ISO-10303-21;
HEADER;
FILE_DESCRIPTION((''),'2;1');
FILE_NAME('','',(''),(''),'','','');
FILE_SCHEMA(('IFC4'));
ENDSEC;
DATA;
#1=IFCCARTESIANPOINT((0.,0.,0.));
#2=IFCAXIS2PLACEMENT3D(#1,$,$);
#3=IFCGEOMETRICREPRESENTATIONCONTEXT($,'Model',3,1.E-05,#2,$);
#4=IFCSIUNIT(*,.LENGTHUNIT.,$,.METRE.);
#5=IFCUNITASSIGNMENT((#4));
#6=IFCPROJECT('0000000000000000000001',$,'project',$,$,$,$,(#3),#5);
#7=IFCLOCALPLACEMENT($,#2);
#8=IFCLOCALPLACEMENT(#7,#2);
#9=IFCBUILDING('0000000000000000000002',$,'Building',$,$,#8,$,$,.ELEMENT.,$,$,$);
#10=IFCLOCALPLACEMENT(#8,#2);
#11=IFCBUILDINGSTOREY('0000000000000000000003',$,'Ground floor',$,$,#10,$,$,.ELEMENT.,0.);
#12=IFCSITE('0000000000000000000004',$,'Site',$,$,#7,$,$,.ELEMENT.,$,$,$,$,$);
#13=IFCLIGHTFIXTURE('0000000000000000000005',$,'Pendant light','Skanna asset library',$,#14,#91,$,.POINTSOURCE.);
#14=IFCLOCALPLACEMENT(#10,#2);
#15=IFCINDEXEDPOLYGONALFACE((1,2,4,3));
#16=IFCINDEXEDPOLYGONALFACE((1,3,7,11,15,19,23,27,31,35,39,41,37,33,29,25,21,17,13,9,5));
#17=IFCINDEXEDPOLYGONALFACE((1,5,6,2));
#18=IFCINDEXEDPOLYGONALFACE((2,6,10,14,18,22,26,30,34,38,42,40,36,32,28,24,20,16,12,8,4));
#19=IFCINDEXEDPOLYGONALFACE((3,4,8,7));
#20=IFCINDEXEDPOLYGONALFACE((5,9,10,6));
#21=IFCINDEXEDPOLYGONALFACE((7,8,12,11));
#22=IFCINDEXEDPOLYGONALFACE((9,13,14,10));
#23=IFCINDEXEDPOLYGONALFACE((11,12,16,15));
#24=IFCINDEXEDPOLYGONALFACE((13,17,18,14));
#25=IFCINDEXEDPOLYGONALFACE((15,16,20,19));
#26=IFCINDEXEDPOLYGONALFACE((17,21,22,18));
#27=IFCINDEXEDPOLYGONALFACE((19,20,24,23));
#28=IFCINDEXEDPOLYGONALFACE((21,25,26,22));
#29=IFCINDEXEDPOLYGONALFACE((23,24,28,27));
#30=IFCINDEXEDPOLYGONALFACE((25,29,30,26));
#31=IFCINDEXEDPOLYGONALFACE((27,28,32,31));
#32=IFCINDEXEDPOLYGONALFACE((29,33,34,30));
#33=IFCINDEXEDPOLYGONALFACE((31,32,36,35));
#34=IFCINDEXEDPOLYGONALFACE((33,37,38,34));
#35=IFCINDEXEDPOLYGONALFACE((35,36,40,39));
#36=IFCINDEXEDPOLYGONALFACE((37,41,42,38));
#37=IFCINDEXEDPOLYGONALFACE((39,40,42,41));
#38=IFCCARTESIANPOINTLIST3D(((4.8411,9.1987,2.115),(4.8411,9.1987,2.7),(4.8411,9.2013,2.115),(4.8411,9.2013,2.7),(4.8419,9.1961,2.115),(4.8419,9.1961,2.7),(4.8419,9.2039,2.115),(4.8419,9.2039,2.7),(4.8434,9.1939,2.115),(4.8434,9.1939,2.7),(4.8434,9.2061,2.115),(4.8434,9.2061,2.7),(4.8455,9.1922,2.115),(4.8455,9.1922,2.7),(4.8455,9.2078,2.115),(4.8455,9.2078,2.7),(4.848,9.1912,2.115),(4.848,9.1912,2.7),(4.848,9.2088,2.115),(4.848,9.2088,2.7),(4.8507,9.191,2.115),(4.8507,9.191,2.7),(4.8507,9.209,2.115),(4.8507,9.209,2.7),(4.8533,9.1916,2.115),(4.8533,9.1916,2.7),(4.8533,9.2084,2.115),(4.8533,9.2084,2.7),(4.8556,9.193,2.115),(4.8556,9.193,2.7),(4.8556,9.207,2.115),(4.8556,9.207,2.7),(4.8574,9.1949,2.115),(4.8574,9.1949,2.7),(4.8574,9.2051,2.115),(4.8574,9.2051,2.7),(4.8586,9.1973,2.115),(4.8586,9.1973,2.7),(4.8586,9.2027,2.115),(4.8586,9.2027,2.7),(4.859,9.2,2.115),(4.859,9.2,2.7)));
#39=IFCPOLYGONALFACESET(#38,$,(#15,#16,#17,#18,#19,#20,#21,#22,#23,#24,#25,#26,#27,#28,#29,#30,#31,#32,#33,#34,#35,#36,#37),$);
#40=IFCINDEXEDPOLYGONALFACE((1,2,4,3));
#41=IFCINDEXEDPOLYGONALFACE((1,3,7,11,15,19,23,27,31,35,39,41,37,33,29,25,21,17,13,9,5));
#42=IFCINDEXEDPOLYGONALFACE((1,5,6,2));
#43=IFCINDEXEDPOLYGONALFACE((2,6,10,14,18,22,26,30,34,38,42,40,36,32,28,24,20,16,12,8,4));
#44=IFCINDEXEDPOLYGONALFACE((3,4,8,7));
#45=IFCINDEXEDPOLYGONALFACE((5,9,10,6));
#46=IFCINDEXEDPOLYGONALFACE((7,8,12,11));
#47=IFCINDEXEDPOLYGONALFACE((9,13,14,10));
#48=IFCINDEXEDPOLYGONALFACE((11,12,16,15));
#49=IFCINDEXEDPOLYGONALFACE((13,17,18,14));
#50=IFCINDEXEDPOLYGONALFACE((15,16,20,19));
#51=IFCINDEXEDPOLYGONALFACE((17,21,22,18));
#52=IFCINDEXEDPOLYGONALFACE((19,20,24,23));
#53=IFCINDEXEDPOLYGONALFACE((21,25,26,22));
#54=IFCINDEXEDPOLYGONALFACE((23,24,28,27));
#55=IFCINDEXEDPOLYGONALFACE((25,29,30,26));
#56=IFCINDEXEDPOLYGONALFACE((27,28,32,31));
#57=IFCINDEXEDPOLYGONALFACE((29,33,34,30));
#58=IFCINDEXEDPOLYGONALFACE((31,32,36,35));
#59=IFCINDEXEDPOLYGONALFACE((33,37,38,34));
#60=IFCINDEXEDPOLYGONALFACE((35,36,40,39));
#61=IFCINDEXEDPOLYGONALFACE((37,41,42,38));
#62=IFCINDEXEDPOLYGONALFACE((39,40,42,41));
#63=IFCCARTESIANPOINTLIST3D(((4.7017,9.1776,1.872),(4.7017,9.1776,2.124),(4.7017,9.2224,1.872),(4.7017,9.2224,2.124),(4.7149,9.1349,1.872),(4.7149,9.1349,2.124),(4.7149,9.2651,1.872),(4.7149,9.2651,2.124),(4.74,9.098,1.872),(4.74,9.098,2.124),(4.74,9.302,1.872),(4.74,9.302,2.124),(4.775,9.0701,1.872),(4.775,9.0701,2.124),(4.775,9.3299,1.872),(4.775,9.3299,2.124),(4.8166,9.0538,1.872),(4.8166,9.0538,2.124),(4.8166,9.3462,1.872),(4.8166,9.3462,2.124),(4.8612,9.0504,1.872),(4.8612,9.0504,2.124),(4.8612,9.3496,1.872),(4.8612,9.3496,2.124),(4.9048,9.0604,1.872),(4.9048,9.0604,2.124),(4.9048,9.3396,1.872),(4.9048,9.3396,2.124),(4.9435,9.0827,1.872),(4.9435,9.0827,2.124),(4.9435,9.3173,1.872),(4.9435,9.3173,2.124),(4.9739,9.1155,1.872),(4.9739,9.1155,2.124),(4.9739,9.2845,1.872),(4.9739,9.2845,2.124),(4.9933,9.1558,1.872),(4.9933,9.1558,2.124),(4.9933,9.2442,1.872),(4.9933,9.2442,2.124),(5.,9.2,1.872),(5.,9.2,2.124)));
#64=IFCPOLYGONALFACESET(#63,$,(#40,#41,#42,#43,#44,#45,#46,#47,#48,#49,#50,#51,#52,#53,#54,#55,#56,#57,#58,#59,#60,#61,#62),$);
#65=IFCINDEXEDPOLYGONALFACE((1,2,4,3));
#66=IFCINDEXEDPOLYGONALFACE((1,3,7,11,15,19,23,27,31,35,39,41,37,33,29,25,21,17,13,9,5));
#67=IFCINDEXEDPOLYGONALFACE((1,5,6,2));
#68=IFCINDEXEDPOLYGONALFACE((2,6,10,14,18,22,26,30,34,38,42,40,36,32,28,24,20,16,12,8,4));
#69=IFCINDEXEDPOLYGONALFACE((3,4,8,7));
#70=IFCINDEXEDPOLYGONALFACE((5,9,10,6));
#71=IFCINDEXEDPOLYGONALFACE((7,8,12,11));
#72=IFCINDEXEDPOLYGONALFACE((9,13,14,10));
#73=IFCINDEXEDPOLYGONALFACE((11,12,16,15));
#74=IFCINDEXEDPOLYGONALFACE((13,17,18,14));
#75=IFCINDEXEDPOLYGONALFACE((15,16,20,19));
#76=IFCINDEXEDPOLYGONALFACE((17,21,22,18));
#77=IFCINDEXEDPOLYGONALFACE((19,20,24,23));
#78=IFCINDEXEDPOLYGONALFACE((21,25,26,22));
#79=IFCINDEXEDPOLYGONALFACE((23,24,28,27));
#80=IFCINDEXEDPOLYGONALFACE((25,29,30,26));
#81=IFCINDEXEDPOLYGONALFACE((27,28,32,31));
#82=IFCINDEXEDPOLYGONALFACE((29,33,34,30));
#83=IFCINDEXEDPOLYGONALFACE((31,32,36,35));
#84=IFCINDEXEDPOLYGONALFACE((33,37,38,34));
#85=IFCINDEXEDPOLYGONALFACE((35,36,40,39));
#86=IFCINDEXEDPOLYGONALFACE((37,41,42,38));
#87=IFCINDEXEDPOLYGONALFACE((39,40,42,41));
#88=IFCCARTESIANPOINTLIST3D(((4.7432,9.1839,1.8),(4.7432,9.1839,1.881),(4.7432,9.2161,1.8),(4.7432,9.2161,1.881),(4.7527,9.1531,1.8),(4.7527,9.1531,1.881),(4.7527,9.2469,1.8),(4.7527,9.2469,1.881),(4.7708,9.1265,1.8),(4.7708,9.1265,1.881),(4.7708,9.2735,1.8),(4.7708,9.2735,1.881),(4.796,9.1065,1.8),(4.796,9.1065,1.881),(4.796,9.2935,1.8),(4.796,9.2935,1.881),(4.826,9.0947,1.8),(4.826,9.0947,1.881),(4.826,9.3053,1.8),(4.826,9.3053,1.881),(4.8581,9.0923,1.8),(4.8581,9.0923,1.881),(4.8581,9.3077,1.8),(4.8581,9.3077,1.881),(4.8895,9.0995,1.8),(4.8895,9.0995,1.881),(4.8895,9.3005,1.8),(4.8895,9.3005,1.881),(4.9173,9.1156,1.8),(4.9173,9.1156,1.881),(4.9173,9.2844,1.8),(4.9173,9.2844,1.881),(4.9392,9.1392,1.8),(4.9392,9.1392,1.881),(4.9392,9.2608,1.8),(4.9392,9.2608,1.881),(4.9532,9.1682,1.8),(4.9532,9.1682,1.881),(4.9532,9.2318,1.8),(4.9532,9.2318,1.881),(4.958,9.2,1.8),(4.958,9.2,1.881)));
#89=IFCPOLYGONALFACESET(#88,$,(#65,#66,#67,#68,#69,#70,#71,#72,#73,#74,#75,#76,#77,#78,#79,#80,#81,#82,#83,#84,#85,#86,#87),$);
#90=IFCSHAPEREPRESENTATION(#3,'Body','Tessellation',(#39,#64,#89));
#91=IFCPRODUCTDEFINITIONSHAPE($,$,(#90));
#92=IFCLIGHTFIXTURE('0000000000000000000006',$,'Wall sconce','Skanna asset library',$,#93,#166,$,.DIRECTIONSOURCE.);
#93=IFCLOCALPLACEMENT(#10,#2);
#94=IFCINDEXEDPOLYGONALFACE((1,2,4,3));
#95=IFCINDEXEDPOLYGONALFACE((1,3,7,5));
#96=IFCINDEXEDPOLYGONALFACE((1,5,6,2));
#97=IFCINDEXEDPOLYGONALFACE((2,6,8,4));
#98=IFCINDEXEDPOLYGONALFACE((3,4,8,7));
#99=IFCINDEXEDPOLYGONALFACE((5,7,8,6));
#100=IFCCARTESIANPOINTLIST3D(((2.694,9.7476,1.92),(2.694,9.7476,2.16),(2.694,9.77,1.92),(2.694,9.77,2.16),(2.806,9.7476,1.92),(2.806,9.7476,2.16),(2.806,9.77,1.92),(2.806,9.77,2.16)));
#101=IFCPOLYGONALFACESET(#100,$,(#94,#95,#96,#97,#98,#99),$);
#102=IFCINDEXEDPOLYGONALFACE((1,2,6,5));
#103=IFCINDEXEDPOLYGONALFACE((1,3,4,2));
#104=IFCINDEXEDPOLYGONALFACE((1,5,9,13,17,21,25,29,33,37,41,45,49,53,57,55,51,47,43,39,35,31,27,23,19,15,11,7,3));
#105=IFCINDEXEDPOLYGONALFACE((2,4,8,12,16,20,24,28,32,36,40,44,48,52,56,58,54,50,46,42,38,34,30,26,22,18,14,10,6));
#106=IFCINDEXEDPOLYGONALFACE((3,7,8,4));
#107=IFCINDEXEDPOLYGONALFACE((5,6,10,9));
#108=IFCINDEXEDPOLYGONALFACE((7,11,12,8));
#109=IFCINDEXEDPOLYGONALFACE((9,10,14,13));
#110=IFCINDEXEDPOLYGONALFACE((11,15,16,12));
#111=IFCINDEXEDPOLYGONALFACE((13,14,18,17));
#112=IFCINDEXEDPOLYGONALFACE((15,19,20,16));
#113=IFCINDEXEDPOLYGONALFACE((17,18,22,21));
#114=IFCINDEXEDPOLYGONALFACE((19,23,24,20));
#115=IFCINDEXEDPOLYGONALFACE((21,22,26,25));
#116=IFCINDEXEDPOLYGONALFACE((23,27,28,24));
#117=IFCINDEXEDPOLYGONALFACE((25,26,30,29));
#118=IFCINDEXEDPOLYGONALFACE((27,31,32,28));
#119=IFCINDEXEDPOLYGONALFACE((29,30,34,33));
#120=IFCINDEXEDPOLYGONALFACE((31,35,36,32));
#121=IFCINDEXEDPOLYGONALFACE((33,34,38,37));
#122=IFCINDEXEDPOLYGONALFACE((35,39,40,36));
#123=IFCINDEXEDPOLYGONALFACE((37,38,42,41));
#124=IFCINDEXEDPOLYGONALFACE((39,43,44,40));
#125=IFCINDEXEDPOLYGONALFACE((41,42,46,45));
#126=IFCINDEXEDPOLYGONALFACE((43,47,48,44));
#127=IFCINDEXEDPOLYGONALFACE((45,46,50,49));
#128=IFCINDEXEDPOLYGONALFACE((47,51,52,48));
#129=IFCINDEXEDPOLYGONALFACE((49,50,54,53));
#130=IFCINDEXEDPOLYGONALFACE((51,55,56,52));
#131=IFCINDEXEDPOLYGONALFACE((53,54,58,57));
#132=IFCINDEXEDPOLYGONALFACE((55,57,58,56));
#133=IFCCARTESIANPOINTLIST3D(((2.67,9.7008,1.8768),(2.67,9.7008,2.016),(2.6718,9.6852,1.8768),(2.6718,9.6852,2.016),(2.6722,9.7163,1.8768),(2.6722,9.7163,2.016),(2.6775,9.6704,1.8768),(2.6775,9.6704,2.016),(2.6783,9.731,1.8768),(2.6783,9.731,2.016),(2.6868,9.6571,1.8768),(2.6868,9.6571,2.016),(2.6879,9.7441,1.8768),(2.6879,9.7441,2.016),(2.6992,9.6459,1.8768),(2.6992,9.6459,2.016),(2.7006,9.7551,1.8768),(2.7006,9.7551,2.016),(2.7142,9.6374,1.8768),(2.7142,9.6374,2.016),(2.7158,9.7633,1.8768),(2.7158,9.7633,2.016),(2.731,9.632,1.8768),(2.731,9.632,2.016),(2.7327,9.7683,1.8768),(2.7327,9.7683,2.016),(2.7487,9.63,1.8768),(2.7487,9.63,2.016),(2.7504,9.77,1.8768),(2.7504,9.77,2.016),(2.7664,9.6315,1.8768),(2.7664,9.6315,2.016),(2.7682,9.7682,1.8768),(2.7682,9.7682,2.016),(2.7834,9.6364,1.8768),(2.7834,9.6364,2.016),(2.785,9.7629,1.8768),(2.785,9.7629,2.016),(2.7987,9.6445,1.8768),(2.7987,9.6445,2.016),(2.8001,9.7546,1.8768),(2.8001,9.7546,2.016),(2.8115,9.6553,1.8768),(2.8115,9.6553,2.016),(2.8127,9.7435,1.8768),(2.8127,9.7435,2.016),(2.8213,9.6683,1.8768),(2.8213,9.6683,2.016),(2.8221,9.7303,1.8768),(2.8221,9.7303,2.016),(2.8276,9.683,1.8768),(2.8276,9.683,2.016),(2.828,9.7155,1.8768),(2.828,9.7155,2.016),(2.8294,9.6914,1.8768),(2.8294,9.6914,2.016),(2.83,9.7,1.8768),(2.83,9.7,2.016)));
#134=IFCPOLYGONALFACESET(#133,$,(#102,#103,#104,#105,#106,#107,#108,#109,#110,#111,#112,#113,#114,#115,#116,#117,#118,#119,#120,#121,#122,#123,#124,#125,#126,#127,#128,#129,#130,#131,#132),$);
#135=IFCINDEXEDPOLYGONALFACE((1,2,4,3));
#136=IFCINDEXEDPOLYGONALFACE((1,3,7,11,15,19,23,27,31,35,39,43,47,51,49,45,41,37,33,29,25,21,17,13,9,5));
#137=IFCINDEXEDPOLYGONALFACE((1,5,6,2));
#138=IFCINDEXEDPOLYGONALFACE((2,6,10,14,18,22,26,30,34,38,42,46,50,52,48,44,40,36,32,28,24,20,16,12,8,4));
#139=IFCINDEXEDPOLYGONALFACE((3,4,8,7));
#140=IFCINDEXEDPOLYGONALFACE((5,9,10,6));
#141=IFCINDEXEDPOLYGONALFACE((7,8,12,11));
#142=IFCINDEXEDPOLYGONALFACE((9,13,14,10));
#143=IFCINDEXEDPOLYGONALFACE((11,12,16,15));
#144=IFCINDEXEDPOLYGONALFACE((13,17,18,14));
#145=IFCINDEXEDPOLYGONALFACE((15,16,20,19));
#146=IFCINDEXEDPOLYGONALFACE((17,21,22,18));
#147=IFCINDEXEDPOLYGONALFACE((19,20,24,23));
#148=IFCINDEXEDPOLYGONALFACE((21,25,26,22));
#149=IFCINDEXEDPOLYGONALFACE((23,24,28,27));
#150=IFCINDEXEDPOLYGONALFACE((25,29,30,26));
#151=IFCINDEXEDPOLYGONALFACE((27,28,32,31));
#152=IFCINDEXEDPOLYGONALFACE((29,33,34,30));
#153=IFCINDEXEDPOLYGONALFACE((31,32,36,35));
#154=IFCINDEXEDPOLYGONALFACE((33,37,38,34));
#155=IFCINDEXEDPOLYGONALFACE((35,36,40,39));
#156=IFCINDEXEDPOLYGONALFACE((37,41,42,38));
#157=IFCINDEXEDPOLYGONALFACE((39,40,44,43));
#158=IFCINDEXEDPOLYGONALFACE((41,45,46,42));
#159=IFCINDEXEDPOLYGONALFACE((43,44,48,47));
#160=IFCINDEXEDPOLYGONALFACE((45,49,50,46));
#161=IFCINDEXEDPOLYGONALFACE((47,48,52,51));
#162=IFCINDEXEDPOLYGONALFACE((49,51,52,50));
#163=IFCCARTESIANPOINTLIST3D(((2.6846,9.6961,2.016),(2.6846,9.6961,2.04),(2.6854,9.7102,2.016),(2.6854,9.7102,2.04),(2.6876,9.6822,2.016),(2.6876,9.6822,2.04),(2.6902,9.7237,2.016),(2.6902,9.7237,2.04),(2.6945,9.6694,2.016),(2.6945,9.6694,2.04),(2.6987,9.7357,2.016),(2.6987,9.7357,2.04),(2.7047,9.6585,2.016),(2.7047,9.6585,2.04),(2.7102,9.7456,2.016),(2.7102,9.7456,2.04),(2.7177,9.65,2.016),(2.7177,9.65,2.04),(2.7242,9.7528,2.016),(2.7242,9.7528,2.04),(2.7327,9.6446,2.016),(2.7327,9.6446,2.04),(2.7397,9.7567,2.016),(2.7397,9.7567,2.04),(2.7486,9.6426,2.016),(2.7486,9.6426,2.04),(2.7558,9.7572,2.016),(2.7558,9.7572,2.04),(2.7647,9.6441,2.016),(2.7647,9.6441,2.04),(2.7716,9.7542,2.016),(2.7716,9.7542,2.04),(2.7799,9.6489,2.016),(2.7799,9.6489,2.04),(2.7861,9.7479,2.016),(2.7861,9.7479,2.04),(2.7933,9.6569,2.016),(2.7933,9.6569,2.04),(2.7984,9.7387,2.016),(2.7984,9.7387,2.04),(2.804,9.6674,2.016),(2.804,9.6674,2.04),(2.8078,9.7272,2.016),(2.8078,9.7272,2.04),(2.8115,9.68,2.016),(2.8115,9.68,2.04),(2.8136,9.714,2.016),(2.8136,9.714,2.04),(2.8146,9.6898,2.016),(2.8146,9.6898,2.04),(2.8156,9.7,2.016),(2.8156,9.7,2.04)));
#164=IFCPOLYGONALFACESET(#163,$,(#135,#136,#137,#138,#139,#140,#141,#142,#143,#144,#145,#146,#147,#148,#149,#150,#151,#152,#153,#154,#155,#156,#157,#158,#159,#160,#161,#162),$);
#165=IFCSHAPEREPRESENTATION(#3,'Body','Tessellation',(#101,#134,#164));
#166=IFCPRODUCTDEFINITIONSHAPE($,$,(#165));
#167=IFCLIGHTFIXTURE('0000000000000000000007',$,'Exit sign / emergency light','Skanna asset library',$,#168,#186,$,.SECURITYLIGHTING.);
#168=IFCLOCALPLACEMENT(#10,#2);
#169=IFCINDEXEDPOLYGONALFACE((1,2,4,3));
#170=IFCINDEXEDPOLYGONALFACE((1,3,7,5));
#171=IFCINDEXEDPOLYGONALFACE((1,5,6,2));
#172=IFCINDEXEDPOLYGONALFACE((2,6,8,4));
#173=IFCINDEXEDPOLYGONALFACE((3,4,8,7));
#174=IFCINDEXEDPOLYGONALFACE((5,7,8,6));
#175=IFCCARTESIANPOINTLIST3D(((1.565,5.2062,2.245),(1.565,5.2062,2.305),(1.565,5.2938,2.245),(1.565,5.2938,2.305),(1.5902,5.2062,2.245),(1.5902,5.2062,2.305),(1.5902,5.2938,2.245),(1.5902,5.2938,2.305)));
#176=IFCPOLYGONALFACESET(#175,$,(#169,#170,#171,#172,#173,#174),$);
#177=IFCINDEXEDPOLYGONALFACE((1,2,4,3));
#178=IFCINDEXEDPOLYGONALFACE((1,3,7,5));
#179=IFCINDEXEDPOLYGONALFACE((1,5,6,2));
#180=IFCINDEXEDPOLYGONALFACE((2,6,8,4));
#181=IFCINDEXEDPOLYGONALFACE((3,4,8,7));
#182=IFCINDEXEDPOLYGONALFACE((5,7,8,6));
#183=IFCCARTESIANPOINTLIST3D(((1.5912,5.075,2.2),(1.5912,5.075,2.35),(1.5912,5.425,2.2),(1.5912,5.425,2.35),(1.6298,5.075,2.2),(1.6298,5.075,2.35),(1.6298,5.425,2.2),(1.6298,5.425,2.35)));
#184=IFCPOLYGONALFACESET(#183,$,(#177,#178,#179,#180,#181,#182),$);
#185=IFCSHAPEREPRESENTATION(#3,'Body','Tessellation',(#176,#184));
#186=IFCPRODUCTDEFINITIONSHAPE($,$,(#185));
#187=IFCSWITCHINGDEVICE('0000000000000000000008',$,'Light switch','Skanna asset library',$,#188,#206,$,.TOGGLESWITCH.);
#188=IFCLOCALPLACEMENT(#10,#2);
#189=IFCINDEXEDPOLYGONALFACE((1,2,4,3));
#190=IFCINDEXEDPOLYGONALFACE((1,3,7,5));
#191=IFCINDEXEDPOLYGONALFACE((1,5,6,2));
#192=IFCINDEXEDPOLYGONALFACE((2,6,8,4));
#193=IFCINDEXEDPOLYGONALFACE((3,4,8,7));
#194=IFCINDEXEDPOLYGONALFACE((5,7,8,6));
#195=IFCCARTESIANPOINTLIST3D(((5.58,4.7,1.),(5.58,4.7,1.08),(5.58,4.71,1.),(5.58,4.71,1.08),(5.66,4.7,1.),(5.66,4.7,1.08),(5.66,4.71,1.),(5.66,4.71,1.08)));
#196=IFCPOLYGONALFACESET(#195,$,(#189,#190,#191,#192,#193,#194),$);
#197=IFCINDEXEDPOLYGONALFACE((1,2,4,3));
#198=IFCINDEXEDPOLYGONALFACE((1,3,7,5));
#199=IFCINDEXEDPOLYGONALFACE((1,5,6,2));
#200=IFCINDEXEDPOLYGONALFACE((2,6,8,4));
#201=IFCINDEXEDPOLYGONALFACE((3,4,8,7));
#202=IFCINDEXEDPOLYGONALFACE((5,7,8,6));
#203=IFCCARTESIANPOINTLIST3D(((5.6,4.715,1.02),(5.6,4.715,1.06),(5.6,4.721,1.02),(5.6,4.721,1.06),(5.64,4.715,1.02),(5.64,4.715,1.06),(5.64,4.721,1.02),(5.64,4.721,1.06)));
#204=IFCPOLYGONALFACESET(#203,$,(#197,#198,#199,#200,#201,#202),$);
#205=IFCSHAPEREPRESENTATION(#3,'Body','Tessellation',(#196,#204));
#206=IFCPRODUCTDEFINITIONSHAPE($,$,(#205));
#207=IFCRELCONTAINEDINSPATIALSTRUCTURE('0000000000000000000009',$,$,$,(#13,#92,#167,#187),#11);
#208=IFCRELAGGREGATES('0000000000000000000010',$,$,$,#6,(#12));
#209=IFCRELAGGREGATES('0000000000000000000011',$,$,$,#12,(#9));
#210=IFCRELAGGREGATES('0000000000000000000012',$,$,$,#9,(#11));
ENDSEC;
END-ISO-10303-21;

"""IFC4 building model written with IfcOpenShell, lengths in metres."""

from ifc_helpers import new_model, si_unit, frame, frame_2d, origin, origin_2d, place, context, project, spatial, rectangle, circle, ellipse, extrude, element, save


model = new_model("IFC4")

# Units and contexts
model_context = context("Model", 3, precision=1e-05, world=origin())
ifc_project = project(units=[si_unit("LENGTHUNIT", "METRE")], contexts=[model_context])

# Site, building, storey
site_placement = place(None, origin())
site = spatial("IfcSite", under=ifc_project, at=site_placement, Name="Site", CompositionType="ELEMENT")
building_placement = place(site_placement, origin())
building = spatial("IfcBuilding", under=site, at=building_placement, Name="Building", CompositionType="ELEMENT")
storey_placement = place(building_placement, origin())
storey = spatial("IfcBuildingStorey", under=building, at=storey_placement, Name="Ground floor", CompositionType="ELEMENT", Elevation=0.0)

# Light fixtures
light_fixture_1_placement = place(storey_placement, frame((4.85, 9.2, 1.8), z_axis=(0.0, 0.0, 1.0), x_axis=(1.0, 0.0, 0.0)))
element("IfcLightFixture", 1, at=light_fixture_1_placement, inside=storey, Name="Pendant light", Description="Skanna asset library", PredefinedType="POINTSOURCE", context=model_context, shape_type="SweptSolid", body=[
    extrude(circle(Radius=0.009, at=origin_2d()), frame((0.0, 0.0, 0.315)), (0.0, 0.0, 1.0), 0.585),
    extrude(circle(Radius=0.15, at=origin_2d()), frame((0.0, 0.0, 0.072)), (0.0, 0.0, 1.0), 0.252),
    extrude(circle(Radius=0.108, at=origin_2d()), origin(), (0.0, 0.0, 1.0), 0.081),
])
light_fixture_2_placement = place(storey_placement, frame((2.75, 9.7, 1.8), z_axis=(0.0, 0.0, 1.0), x_axis=(1.0, 0.0, 0.0)))
element("IfcLightFixture", 2, at=light_fixture_2_placement, inside=storey, Name="Wall sconce", Description="Skanna asset library", PredefinedType="DIRECTIONSOURCE", context=model_context, shape_type="SweptSolid", body=[
    extrude(rectangle(XDim=0.112, YDim=0.0224, at=frame_2d((0.0, 0.0588))), frame((0.0, 0.0, 0.12)), (0.0, 0.0, 1.0), 0.24),
    extrude(ellipse(SemiAxis1=0.08, SemiAxis2=0.07, at=origin_2d()), frame((0.0, 0.0, 0.0768)), (0.0, 0.0, 1.0), 0.1392),
    extrude(ellipse(SemiAxis1=0.0656, SemiAxis2=0.0574, at=origin_2d()), frame((0.0, 0.0, 0.216)), (0.0, 0.0, 1.0), 0.024),
])
light_fixture_3_placement = place(storey_placement, frame((1.6, 5.25, 2.2), z_axis=(0.0, 0.0, 1.0), x_axis=(0.0, 1.0, 0.0)))
element("IfcLightFixture", 3, at=light_fixture_3_placement, inside=storey, Name="Exit sign / emergency light", Description="Skanna asset library", PredefinedType="SECURITYLIGHTING", context=model_context, shape_type="SweptSolid", body=[
    extrude(rectangle(XDim=0.0875, YDim=0.0252, at=frame_2d((0.0, 0.0224))), frame((0.0, 0.0, 0.045)), (0.0, 0.0, 1.0), 0.06),
    extrude(rectangle(XDim=0.35, YDim=0.0385, at=frame_2d((0.0, -0.0105))), origin(), (0.0, 0.0, 1.0), 0.15),
])

# Switching device
switching_device_placement = place(storey_placement, frame((5.62, 4.71, 1.0), z_axis=(0.0, 0.0, 1.0), x_axis=(-1.0, 0.0, 0.0)))
element("IfcSwitchingDevice", 4, at=switching_device_placement, inside=storey, Name="Light switch", Description="Skanna asset library", PredefinedType="TOGGLESWITCH", context=model_context, shape_type="SweptSolid", body=[
    extrude(rectangle(XDim=0.08, YDim=0.01, at=frame_2d((0.0, 0.005))), origin(), (0.0, 0.0, 1.0), 0.08),
    extrude(rectangle(XDim=0.04, YDim=0.006, at=frame_2d((0.0, -0.008))), frame((0.0, 0.0, 0.02)), (0.0, 0.0, 1.0), 0.04),
])

save(model, "model.ifc")
